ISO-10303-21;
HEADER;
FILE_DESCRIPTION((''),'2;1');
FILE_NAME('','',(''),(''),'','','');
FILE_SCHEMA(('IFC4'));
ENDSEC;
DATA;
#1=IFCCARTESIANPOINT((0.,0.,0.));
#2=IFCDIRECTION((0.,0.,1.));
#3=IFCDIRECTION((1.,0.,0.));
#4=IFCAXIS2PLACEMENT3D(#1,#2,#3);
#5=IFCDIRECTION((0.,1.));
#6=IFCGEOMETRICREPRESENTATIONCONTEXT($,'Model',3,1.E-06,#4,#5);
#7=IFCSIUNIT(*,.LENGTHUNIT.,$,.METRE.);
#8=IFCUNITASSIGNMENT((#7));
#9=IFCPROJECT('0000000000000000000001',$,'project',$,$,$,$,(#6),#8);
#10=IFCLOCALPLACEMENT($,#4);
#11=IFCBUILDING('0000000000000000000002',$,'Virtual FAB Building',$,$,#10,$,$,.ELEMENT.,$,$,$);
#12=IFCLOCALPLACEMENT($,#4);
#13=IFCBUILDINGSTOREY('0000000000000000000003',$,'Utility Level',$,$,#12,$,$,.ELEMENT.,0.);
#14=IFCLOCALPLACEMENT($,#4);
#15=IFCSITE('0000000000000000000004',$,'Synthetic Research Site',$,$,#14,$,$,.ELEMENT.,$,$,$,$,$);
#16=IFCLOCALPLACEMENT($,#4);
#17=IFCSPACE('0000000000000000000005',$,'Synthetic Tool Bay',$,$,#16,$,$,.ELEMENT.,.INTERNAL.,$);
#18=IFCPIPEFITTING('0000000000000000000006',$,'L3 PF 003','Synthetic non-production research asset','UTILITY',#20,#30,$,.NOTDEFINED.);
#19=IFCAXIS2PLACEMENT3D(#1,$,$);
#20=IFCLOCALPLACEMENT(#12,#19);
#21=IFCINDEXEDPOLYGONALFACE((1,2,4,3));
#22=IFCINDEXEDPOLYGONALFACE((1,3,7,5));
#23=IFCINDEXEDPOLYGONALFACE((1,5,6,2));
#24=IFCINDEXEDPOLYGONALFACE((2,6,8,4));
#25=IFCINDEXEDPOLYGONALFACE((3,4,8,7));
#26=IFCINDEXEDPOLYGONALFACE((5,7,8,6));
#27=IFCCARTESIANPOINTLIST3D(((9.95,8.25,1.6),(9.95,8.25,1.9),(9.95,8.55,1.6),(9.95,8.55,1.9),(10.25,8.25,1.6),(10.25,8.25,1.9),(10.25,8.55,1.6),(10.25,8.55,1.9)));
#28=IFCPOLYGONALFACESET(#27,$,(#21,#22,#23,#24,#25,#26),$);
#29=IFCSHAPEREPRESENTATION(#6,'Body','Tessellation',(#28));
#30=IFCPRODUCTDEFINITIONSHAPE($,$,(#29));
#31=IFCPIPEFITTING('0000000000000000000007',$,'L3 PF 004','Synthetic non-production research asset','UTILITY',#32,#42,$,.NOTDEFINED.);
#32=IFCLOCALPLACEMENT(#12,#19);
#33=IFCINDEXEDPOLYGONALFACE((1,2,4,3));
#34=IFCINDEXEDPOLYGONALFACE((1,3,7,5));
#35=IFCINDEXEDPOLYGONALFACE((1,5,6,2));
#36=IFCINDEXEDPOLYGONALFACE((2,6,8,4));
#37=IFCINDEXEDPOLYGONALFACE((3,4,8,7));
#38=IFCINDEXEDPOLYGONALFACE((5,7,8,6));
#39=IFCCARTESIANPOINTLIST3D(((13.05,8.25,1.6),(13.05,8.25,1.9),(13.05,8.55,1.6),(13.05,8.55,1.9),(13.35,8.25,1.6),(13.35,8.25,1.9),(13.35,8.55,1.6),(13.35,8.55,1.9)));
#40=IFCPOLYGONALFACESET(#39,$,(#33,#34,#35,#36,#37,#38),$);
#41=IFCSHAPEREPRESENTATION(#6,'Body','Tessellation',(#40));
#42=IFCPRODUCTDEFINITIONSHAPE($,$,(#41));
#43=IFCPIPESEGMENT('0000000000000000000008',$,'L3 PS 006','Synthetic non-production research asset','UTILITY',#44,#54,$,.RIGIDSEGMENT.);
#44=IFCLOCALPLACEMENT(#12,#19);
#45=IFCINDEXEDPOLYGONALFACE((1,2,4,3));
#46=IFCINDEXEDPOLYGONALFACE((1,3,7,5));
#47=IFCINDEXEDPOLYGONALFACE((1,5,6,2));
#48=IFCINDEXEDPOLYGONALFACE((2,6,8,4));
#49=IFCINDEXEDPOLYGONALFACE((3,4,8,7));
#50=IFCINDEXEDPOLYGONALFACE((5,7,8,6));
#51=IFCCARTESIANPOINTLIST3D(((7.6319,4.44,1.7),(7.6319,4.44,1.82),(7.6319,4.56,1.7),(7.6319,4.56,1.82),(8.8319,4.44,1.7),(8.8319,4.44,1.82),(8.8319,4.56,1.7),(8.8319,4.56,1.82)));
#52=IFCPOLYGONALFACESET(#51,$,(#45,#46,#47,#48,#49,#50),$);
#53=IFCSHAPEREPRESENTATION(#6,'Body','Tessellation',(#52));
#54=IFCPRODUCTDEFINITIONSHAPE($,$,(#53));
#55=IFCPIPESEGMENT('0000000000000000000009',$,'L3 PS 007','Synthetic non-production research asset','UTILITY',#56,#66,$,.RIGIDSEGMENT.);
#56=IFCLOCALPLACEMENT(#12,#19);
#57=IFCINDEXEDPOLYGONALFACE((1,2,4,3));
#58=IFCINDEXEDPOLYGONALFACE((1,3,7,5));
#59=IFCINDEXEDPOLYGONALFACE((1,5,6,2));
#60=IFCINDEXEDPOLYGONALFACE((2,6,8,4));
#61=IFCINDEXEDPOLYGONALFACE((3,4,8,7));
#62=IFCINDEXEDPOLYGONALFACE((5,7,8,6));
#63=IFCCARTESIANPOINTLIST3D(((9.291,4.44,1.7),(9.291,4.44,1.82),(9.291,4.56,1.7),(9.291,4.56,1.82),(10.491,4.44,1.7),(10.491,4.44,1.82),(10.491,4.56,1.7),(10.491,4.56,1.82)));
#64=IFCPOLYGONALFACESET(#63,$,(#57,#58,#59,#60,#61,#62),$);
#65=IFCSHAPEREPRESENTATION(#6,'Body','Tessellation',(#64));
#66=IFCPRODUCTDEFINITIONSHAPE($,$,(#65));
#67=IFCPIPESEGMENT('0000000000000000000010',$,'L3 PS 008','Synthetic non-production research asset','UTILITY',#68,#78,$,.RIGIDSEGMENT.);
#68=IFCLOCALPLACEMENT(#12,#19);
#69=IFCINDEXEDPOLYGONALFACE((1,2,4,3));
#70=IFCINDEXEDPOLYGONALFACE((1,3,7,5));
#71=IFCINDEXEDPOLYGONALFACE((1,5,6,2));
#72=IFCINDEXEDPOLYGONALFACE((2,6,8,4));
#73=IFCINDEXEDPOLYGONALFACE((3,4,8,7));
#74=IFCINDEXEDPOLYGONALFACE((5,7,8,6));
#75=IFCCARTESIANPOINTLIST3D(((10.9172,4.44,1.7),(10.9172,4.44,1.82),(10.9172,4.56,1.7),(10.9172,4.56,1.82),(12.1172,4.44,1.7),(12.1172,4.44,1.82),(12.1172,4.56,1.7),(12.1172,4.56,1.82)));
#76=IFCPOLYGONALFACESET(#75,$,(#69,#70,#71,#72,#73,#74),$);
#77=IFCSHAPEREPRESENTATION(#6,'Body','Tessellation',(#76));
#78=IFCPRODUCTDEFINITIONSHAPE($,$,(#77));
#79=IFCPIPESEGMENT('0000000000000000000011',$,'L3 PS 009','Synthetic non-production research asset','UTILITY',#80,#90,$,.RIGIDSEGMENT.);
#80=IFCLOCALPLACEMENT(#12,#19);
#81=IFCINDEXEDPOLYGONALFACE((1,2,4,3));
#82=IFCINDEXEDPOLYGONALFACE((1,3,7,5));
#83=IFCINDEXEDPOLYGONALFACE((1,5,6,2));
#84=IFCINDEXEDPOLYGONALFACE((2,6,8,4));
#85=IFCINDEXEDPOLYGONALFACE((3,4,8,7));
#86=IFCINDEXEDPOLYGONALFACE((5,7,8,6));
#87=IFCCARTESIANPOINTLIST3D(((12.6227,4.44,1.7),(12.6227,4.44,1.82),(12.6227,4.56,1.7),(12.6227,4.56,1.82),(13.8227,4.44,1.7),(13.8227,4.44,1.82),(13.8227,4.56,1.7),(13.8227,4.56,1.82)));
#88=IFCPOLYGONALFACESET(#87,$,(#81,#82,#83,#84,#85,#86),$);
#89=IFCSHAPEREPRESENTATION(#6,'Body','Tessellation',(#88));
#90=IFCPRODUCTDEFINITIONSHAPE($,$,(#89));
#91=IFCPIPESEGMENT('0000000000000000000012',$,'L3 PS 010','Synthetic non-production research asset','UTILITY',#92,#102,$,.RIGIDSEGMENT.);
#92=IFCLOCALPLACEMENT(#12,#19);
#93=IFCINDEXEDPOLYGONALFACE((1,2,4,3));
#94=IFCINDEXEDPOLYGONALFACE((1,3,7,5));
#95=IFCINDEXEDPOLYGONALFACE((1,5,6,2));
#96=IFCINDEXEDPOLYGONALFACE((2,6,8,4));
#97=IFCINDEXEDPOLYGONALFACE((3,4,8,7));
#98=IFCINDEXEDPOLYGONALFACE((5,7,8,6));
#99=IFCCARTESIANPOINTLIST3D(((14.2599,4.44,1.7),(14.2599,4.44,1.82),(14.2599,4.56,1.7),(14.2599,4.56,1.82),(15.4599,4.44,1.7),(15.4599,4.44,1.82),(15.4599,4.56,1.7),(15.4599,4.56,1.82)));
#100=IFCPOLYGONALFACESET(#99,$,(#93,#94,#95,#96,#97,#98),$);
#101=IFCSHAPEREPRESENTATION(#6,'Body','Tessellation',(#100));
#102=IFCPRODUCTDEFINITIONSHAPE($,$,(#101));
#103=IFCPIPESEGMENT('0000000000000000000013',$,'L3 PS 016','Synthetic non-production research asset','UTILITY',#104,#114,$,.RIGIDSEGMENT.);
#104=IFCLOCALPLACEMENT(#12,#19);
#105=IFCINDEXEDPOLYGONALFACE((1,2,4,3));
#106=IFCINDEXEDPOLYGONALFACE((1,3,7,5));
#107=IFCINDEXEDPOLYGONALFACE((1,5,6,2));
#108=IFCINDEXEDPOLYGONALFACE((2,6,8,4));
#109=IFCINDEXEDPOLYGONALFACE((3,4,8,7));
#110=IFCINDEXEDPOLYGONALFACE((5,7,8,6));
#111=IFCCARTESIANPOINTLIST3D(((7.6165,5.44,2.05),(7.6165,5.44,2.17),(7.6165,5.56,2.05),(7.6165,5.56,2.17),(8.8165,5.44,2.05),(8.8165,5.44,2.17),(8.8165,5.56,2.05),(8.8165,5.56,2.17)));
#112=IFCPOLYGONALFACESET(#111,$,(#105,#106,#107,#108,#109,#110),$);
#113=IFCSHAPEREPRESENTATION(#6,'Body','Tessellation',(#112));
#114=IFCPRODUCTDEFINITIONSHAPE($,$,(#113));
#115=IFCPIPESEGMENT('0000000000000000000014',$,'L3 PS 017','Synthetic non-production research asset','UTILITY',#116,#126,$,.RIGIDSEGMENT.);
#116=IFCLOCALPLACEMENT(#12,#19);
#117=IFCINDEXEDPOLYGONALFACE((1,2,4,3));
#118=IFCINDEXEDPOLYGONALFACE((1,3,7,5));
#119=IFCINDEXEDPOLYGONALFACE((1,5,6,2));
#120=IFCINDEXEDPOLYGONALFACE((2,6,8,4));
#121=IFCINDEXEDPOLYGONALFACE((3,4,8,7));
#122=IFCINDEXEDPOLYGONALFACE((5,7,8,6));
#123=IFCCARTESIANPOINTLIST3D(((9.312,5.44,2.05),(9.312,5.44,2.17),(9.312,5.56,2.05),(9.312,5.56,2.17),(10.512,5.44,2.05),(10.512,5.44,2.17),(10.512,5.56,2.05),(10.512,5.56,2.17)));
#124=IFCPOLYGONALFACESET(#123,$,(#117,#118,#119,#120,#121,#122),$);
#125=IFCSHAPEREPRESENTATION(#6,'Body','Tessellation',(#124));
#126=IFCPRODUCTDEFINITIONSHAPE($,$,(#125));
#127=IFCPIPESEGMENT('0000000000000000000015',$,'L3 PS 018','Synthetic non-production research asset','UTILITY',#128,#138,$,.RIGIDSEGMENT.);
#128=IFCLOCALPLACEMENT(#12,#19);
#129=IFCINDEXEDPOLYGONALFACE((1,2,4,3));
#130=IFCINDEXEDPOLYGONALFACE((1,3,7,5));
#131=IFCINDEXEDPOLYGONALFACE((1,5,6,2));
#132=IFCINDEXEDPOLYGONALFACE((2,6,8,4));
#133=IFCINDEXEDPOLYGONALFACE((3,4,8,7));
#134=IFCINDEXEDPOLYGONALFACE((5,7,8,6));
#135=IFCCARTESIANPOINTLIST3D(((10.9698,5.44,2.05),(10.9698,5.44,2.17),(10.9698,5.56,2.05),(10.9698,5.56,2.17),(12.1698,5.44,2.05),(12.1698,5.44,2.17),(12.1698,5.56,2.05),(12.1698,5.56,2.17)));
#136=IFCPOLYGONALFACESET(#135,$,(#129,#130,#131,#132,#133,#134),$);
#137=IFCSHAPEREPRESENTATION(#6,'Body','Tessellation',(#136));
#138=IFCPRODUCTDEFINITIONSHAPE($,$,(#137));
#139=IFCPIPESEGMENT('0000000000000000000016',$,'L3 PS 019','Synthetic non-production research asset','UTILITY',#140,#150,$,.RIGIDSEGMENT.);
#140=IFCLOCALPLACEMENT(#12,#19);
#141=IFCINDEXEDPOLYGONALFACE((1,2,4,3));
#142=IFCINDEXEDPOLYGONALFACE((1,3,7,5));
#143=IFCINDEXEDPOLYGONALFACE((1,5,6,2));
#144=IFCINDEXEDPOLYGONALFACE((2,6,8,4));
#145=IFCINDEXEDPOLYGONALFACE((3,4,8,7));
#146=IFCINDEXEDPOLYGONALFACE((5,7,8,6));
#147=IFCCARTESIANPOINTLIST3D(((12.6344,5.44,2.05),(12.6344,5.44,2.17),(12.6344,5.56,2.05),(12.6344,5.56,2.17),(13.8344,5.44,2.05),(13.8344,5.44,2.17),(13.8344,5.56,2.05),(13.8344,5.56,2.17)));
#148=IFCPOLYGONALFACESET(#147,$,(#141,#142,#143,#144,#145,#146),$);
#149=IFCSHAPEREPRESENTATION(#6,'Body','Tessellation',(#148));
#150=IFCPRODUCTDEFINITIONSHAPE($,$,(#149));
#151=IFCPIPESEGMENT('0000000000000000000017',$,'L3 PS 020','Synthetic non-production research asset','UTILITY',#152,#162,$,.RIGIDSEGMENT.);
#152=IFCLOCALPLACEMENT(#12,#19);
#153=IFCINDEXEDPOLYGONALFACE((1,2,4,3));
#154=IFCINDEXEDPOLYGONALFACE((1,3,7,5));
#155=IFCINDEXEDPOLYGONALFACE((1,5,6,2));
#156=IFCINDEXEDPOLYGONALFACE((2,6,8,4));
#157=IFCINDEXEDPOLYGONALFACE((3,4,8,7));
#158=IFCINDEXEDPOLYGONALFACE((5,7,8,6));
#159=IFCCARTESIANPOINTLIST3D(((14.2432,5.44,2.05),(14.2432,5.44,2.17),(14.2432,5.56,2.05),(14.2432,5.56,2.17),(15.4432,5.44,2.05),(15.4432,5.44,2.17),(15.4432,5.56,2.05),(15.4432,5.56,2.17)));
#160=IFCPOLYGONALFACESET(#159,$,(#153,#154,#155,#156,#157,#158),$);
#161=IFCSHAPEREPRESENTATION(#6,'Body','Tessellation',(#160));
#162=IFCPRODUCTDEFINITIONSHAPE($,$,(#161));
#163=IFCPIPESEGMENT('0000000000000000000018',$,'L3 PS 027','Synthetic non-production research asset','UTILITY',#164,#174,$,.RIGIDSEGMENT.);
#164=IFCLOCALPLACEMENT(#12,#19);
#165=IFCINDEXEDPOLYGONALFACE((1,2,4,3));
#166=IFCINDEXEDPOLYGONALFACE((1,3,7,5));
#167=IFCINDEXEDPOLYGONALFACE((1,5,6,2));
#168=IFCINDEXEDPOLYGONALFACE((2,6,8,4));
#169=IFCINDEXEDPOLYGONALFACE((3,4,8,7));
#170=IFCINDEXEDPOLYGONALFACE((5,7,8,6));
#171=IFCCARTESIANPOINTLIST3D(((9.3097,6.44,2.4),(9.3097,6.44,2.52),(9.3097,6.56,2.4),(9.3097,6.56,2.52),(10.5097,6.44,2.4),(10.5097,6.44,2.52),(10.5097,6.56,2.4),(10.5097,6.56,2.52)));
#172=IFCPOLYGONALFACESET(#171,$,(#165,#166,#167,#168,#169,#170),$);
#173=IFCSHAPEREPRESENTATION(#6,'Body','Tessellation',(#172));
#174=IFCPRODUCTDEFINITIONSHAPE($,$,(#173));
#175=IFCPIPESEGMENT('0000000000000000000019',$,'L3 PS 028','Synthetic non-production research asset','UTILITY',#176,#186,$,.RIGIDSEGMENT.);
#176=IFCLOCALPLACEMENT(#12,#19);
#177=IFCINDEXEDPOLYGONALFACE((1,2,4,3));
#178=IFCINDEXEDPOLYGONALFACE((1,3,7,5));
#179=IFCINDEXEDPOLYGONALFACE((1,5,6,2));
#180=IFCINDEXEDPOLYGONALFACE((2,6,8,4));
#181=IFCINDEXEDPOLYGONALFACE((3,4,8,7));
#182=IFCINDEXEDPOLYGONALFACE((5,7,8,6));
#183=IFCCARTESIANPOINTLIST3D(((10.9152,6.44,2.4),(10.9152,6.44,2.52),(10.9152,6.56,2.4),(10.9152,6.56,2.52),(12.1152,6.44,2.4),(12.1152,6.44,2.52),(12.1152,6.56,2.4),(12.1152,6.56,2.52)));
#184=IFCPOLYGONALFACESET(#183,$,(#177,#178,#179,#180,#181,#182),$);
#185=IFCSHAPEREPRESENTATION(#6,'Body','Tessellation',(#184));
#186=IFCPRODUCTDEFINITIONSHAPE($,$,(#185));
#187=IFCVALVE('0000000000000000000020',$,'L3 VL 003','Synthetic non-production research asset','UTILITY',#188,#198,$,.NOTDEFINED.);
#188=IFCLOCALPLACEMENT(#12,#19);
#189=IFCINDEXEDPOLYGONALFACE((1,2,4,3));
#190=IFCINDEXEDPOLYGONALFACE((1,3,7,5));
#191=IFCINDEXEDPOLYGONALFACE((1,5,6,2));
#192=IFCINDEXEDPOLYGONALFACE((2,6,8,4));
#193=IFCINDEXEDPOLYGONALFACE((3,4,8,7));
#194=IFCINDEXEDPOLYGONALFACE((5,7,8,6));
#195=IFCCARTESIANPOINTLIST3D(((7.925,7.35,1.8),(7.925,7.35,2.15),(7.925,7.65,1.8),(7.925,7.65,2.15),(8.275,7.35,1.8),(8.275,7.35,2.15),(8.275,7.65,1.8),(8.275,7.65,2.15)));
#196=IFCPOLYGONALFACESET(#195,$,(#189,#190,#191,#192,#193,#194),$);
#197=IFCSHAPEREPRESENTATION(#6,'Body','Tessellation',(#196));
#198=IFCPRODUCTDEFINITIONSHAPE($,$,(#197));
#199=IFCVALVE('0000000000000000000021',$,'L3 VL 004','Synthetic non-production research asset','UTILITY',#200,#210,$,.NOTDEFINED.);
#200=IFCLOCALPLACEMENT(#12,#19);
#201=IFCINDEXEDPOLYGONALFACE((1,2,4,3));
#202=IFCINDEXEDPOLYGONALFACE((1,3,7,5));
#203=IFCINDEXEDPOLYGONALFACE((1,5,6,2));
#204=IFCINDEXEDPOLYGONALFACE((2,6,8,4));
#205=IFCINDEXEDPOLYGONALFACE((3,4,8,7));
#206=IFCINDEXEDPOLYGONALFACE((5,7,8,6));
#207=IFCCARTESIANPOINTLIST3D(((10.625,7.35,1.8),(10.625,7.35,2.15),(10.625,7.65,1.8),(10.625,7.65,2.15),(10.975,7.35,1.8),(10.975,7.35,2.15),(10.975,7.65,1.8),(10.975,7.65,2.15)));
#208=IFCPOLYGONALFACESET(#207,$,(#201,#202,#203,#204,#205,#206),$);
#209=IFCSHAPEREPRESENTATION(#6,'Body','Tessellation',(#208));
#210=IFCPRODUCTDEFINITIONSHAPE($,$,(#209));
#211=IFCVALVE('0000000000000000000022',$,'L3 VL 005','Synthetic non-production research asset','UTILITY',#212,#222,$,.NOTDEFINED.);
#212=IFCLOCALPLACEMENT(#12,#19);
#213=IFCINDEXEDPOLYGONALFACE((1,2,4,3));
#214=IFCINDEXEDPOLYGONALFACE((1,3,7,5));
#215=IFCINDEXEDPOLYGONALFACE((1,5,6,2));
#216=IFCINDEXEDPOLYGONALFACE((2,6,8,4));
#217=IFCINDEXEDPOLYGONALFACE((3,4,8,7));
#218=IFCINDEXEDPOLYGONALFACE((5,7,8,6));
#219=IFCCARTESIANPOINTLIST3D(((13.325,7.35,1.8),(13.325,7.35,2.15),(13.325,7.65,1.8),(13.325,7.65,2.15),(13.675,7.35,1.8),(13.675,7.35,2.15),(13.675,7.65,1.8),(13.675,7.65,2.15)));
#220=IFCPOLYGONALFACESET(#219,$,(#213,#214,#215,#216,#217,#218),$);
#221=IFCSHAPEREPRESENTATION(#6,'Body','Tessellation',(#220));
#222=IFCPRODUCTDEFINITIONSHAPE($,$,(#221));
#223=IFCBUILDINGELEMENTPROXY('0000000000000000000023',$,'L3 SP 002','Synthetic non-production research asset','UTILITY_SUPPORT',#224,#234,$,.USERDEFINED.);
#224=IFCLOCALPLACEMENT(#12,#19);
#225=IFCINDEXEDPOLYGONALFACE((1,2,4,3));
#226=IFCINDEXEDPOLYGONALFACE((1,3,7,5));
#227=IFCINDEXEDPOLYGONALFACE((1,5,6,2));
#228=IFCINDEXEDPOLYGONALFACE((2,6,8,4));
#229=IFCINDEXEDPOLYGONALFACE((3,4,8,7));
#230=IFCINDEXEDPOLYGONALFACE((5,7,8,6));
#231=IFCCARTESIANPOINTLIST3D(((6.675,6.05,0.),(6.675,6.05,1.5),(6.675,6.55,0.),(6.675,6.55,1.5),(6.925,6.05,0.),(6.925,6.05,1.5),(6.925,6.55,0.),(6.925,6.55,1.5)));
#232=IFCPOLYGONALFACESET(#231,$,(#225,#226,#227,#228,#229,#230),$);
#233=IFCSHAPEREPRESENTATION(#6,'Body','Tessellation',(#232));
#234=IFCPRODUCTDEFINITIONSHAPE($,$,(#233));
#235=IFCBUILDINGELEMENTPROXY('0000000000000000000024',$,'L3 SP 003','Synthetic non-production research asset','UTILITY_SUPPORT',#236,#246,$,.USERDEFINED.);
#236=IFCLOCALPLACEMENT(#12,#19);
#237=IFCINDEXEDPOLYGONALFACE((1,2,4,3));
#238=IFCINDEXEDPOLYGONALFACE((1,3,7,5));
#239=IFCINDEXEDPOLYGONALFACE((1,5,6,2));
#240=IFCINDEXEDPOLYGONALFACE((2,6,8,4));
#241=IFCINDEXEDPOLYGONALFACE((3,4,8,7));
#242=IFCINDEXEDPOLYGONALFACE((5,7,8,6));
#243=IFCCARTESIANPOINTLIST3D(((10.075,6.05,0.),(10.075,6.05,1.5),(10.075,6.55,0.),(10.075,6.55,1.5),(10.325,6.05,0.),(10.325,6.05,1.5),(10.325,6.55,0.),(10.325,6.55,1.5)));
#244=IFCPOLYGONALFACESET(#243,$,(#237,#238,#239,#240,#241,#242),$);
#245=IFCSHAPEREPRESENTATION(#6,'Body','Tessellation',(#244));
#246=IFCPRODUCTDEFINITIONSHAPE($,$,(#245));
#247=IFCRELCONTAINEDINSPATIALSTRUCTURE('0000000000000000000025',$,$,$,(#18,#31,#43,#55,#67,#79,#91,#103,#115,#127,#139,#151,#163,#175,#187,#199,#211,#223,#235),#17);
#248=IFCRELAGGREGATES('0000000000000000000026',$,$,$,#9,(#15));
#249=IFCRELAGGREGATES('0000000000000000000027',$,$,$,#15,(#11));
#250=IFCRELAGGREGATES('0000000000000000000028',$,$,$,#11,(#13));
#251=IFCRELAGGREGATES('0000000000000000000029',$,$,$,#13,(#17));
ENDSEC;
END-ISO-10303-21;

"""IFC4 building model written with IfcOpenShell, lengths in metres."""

from ifc_helpers import new_model, si_unit, direction, frame, origin_with_axes, origin_2d_with_axis, place, context, project, spatial, rectangle, extrude, element, save


model = new_model("IFC4")

# Units and contexts
model_context = context("Model", 3, precision=1e-06, world=origin_with_axes(), true_north=direction((0.0, 1.0)))
ifc_project = project(units=[si_unit("LENGTHUNIT", "METRE")], contexts=[model_context])

# Site, building, storey, space
site_placement = place(None, origin_with_axes())
site = spatial("IfcSite", under=ifc_project, at=site_placement, Name="Synthetic Research Site", CompositionType="ELEMENT")
building_placement = place(None, origin_with_axes())
building = spatial("IfcBuilding", under=site, at=building_placement, Name="Virtual FAB Building", CompositionType="ELEMENT")
storey_placement = place(None, origin_with_axes())
storey = spatial("IfcBuildingStorey", under=building, at=storey_placement, Name="Utility Level", CompositionType="ELEMENT", Elevation=0.0)
space_placement = place(None, origin_with_axes())
space = spatial("IfcSpace", under=storey, at=space_placement, Name="Synthetic Tool Bay", CompositionType="ELEMENT", PredefinedType="INTERNAL")

# Pipe fittings
for number, where, z_axis, x_axis, name in (
    (1, (10.1, 8.4, 1.6), (0.0, 0.0, 1.0), (1.0, 0.0, 0.0), "L3 PF 003"),
    (2, (13.2, 8.4, 1.6), (0.0, 0.0, 1.0), (1.0, 0.0, 0.0), "L3 PF 004"),
):
    element("IfcPipeFitting", number, at=place(None, frame(where, z_axis=z_axis, x_axis=x_axis)), inside=space, Name=name, Description="Synthetic non-production research asset", ObjectType="UTILITY", PredefinedType="NOTDEFINED", context=model_context, shape_type="SweptSolid", body=[
        extrude(rectangle(XDim=0.3, YDim=0.3, at=origin_2d_with_axis()), origin_with_axes(), (0.0, 0.0, 1.0), 0.3),
    ])

# Pipe segments
for number, where, z_axis, x_axis, name in (
    (3, (8.2319, 4.5, 1.7), (0.0, 0.0, 1.0), (1.0, 0.0, 0.0), "L3 PS 006"),
    (4, (9.891, 4.5, 1.7), (0.0, 0.0, 1.0), (1.0, 0.0, 0.0), "L3 PS 007"),
    (5, (11.5172, 4.5, 1.7), (0.0, 0.0, 1.0), (1.0, 0.0, 0.0), "L3 PS 008"),
    (6, (13.2227, 4.5, 1.7), (0.0, 0.0, 1.0), (1.0, 0.0, 0.0), "L3 PS 009"),
    (7, (14.8599, 4.5, 1.7), (0.0, 0.0, 1.0), (1.0, 0.0, 0.0), "L3 PS 010"),
    (8, (8.2165, 5.5, 2.05), (0.0, 0.0, 1.0), (1.0, 0.0, 0.0), "L3 PS 016"),
    (9, (9.912, 5.5, 2.05), (0.0, 0.0, 1.0), (1.0, 0.0, 0.0), "L3 PS 017"),
    (10, (11.5698, 5.5, 2.05), (0.0, 0.0, 1.0), (1.0, 0.0, 0.0), "L3 PS 018"),
    (11, (13.2344, 5.5, 2.05), (0.0, 0.0, 1.0), (1.0, 0.0, 0.0), "L3 PS 019"),
    (12, (14.8432, 5.5, 2.05), (0.0, 0.0, 1.0), (1.0, 0.0, 0.0), "L3 PS 020"),
    (13, (9.9097, 6.5, 2.4), (0.0, 0.0, 1.0), (1.0, 0.0, 0.0), "L3 PS 027"),
    (14, (11.5152, 6.5, 2.4), (0.0, 0.0, 1.0), (1.0, 0.0, 0.0), "L3 PS 028"),
):
    element("IfcPipeSegment", number, at=place(None, frame(where, z_axis=z_axis, x_axis=x_axis)), inside=space, Name=name, Description="Synthetic non-production research asset", ObjectType="UTILITY", PredefinedType="RIGIDSEGMENT", context=model_context, shape_type="SweptSolid", body=[
        extrude(rectangle(XDim=1.2, YDim=0.12, at=origin_2d_with_axis()), origin_with_axes(), (0.0, 0.0, 1.0), 0.12),
    ])

# Valves
for number, where, z_axis, x_axis, name in (
    (15, (8.1, 7.5, 1.8), (0.0, 0.0, 1.0), (1.0, 0.0, 0.0), "L3 VL 003"),
    (16, (10.8, 7.5, 1.8), (0.0, 0.0, 1.0), (1.0, 0.0, 0.0), "L3 VL 004"),
    (17, (13.5, 7.5, 1.8), (0.0, 0.0, 1.0), (1.0, 0.0, 0.0), "L3 VL 005"),
):
    element("IfcValve", number, at=place(None, frame(where, z_axis=z_axis, x_axis=x_axis)), inside=space, Name=name, Description="Synthetic non-production research asset", ObjectType="UTILITY", PredefinedType="NOTDEFINED", context=model_context, shape_type="SweptSolid", body=[
        extrude(rectangle(XDim=0.35, YDim=0.3, at=origin_2d_with_axis()), origin_with_axes(), (0.0, 0.0, 1.0), 0.35),
    ])

# Building element proxies
for number, where, z_axis, x_axis, name in (
    (18, (6.8, 6.3, 0.0), (0.0, 0.0, 1.0), (1.0, 0.0, 0.0), "L3 SP 002"),
    (19, (10.2, 6.3, 0.0), (0.0, 0.0, 1.0), (1.0, 0.0, 0.0), "L3 SP 003"),
):
    element("IfcBuildingElementProxy", number, at=place(None, frame(where, z_axis=z_axis, x_axis=x_axis)), inside=space, Name=name, Description="Synthetic non-production research asset", ObjectType="UTILITY_SUPPORT", PredefinedType="USERDEFINED", context=model_context, shape_type="SweptSolid", body=[
        extrude(rectangle(XDim=0.25, YDim=0.5, at=origin_2d_with_axis()), origin_with_axes(), (0.0, 0.0, 1.0), 1.5),
    ])

save(model, "model.ifc")
